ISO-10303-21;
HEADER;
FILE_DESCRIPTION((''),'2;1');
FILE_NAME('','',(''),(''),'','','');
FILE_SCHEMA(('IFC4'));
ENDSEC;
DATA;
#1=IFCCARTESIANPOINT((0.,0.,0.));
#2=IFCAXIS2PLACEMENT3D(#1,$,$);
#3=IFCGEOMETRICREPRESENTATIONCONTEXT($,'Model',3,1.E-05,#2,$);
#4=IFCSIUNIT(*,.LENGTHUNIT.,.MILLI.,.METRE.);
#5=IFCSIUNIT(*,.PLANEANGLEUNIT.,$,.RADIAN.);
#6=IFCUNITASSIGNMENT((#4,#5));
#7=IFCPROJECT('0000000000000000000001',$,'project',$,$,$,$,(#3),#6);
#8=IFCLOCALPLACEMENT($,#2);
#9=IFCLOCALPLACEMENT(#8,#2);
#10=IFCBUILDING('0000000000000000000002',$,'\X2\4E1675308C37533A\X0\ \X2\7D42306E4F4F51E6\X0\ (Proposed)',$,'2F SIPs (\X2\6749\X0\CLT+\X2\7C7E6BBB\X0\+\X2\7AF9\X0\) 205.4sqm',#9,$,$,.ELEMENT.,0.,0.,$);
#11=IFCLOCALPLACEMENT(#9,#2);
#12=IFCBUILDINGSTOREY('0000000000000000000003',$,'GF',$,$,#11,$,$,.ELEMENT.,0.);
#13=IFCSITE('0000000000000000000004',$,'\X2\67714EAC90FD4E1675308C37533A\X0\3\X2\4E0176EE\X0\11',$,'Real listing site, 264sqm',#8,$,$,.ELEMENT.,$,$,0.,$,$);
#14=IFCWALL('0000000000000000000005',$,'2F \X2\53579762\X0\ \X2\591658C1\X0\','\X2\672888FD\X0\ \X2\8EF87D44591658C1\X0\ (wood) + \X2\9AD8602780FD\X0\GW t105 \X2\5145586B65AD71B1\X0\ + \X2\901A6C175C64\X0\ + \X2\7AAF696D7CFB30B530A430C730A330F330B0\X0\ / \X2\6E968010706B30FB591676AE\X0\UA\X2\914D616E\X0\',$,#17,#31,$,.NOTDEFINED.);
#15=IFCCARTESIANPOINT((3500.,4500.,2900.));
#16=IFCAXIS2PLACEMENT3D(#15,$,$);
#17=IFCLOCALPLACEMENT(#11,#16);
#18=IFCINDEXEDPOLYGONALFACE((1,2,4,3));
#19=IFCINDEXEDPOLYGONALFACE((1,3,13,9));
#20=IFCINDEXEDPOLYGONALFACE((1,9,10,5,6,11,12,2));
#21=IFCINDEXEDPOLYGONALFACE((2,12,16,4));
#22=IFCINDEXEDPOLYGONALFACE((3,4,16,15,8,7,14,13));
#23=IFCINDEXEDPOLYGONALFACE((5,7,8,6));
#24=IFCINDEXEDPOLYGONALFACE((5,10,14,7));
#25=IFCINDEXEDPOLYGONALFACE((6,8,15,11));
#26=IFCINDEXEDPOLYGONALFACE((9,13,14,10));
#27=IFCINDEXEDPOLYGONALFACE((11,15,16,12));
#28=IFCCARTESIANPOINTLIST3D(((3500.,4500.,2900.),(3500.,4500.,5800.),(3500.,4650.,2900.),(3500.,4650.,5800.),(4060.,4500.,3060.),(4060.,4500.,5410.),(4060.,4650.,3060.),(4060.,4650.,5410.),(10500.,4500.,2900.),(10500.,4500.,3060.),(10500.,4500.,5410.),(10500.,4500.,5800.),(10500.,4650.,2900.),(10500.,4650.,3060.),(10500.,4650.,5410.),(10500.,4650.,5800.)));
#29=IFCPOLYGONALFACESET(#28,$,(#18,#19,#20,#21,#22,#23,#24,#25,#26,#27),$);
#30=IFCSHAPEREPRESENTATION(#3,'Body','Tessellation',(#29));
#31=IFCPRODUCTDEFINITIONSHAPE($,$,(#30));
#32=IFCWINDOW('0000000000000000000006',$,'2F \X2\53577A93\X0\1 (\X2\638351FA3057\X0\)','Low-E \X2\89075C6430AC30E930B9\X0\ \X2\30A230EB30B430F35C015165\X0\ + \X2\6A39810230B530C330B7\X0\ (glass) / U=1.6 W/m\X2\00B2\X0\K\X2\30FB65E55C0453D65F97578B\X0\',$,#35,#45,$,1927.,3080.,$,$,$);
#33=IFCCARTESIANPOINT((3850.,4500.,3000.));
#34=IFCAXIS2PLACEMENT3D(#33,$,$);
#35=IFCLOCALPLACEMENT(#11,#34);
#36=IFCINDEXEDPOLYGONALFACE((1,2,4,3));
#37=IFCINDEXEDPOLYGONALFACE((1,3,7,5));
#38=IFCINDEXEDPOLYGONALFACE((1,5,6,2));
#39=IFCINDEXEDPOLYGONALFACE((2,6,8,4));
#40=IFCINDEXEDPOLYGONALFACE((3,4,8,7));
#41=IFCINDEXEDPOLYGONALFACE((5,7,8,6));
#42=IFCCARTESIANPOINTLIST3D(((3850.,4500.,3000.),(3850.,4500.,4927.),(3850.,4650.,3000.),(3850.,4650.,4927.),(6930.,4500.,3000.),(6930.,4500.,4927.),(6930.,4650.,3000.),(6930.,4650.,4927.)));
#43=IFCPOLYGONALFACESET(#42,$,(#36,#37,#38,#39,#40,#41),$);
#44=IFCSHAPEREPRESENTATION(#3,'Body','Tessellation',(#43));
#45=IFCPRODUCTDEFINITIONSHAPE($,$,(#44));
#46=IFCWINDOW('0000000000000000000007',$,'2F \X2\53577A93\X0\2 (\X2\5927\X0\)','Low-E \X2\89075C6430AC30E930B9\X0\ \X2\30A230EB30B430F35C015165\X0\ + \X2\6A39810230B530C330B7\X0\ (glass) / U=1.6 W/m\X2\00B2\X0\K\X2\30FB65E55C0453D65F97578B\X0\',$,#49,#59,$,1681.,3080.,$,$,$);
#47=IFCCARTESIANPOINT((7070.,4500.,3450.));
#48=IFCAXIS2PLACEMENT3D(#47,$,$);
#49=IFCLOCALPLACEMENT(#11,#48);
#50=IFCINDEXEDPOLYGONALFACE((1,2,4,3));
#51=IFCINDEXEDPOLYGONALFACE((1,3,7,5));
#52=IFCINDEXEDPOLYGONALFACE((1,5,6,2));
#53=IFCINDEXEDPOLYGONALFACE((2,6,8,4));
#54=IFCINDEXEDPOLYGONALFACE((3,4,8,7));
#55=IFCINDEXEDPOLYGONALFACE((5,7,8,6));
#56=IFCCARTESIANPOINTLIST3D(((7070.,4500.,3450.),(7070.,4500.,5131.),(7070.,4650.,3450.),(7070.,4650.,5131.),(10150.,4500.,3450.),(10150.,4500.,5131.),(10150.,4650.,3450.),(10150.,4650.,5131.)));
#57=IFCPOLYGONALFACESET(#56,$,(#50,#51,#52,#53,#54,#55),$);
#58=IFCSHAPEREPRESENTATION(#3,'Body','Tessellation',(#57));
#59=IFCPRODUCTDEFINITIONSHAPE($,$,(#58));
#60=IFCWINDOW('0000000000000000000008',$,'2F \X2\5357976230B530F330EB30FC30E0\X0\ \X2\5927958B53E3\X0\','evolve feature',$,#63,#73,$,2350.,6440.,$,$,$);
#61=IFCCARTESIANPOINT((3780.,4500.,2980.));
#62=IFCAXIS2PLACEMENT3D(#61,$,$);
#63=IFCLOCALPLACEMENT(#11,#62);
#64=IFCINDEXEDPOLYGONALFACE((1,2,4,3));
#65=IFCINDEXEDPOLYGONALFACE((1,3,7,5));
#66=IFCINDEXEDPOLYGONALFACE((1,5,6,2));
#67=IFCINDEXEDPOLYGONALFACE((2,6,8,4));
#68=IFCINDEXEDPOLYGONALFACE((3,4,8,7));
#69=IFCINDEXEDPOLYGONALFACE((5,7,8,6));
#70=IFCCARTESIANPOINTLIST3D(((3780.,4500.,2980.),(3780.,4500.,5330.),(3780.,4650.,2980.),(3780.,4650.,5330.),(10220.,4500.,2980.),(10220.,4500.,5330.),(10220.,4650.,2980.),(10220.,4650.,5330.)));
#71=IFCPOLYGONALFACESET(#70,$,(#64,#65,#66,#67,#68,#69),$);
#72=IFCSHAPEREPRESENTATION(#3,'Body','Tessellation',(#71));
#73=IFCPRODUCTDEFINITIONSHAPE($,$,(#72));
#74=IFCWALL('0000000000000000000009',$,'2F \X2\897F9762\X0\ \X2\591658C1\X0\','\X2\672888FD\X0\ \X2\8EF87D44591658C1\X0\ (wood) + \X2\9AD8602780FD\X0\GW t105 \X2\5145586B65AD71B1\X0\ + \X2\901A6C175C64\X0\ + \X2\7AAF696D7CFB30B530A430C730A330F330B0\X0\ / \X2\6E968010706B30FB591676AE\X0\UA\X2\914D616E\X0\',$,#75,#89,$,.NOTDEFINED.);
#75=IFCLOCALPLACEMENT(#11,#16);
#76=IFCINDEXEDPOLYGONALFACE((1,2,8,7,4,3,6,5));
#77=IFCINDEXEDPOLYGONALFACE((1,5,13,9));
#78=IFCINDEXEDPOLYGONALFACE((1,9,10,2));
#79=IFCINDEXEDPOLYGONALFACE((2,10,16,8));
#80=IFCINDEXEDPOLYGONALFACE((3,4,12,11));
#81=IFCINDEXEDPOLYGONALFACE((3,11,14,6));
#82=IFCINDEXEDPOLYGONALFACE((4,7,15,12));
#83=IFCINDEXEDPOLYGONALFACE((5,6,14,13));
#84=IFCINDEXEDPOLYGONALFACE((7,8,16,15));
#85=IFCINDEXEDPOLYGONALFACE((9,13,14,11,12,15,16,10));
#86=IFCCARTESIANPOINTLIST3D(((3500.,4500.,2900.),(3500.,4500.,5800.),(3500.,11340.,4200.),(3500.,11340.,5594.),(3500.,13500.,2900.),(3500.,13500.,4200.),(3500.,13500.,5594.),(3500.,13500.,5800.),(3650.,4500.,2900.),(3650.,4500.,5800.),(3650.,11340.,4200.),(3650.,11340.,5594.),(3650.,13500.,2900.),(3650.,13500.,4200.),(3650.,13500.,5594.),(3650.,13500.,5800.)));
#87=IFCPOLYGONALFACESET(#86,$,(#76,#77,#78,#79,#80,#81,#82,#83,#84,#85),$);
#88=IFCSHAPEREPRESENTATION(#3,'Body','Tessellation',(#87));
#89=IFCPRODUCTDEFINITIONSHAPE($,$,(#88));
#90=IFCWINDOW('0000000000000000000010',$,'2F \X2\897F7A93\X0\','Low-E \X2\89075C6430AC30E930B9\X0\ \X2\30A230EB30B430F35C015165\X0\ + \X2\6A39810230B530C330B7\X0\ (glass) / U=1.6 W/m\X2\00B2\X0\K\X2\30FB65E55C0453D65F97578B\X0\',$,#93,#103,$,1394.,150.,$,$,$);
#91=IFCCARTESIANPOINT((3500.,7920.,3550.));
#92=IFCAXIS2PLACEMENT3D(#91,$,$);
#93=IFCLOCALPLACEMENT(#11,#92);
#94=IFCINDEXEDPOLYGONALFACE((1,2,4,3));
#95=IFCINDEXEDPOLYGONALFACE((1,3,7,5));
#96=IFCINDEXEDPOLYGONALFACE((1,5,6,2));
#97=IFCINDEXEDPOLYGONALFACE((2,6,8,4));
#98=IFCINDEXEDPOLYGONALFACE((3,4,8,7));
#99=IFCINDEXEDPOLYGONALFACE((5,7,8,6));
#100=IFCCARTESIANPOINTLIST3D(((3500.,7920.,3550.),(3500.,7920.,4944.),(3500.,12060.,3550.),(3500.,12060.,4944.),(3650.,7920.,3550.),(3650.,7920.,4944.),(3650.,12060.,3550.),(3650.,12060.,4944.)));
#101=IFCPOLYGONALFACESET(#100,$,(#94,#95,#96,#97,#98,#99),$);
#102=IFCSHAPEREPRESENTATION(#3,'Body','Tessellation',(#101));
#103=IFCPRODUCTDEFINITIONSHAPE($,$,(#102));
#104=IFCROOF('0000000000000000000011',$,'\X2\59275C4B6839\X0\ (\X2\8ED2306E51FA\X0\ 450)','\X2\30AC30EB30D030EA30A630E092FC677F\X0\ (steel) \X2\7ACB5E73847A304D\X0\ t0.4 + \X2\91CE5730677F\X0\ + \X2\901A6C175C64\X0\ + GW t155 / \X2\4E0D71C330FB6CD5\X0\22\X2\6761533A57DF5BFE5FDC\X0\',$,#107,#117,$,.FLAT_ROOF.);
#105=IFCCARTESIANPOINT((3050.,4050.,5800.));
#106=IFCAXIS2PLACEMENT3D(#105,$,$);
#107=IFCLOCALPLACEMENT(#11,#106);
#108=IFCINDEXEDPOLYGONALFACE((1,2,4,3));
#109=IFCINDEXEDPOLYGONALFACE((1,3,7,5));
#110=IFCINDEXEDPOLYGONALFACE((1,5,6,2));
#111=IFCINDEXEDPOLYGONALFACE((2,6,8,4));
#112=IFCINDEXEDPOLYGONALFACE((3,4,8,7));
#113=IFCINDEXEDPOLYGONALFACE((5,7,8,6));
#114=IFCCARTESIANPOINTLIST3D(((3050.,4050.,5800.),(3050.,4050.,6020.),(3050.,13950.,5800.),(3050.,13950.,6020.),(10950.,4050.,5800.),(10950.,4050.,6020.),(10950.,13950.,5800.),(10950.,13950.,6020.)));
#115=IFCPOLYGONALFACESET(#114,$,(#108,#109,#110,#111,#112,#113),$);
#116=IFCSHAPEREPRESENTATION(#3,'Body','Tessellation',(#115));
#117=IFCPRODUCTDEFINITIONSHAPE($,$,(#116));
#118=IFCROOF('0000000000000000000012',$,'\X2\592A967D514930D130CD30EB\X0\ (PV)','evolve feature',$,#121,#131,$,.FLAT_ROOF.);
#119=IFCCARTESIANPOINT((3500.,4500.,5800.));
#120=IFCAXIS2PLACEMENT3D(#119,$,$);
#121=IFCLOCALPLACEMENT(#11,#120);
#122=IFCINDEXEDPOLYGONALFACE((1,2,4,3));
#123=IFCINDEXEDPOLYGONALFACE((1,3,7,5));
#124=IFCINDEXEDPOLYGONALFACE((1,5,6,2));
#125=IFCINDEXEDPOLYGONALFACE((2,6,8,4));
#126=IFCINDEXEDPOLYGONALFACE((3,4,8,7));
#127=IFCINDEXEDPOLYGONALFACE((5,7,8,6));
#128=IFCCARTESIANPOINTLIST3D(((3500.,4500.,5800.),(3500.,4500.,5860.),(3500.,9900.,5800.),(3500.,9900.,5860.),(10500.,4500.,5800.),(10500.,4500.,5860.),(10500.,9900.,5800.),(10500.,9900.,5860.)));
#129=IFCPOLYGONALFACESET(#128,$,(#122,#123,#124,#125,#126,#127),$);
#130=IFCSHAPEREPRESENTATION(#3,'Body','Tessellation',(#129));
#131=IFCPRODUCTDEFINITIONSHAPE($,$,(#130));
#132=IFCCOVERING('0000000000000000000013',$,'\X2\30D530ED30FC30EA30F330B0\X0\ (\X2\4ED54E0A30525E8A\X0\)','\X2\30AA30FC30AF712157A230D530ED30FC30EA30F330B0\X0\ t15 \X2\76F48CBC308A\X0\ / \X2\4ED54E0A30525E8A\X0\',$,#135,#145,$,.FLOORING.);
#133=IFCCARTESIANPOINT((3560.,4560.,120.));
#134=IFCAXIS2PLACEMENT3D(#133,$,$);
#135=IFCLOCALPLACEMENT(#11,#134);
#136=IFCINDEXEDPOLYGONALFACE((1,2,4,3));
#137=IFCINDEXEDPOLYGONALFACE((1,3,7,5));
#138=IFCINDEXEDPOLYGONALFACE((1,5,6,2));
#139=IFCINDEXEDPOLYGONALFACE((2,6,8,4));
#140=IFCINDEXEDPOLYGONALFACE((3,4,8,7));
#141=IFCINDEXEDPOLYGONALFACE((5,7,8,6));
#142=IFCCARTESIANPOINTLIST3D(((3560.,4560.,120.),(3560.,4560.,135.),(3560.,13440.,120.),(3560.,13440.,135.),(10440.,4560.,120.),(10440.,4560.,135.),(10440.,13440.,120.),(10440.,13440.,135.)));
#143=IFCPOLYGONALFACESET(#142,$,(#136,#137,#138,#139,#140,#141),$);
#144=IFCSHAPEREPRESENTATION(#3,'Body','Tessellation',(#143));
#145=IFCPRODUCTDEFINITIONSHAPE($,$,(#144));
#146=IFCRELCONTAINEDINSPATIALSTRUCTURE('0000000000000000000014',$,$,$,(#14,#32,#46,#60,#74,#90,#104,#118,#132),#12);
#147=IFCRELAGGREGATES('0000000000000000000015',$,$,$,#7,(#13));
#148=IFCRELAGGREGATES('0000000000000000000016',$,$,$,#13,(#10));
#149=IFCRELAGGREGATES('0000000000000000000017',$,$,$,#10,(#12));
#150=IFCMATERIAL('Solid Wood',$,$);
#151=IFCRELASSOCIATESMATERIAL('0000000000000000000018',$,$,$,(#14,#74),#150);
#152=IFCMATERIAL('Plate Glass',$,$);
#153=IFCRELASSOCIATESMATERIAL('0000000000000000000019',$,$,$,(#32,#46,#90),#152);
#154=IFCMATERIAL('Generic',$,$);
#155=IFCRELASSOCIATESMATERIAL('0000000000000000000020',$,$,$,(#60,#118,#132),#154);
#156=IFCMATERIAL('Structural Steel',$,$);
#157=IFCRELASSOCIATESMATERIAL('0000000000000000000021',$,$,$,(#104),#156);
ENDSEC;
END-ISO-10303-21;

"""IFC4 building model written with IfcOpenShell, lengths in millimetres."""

from ifc_helpers import new_model, si_unit, frame, frame_2d, origin, place, context, project, spatial, rectangle, extrude, material, element, fill, save


model = new_model("IFC4")

# Units and contexts
model_context = context("Model", 3, precision=1e-05, world=origin())
ifc_project = project(units=[si_unit("LENGTHUNIT", "METRE", prefix="MILLI"), si_unit("PLANEANGLEUNIT", "RADIAN")], contexts=[model_context])

# Site, building, storey
site_placement = place(None, origin())
site = spatial("IfcSite", under=ifc_project, at=site_placement, Name="東京都世田谷区3丁目11", ObjectType="Real listing site, 264sqm", CompositionType="ELEMENT", RefElevation=0.0)
building_placement = place(site_placement, origin())
building = spatial("IfcBuilding", under=site, at=building_placement, Name="世田谷区 終の住処 (Proposed)", ObjectType="2F SIPs (杉CLT+籾殻+竹) 205.4sqm", CompositionType="ELEMENT", ElevationOfRefHeight=0.0, ElevationOfTerrain=0.0)
storey_placement = place(building_placement, origin())
storey = spatial("IfcBuildingStorey", under=building, at=storey_placement, Name="GF", CompositionType="ELEMENT", Elevation=0.0)

# Shared definitions
ifc_material_1 = material(Name="Solid Wood")

# Shared definitions
ifc_material_2 = material(Name="Plate Glass")
ifc_material_3 = material(Name="Generic")

# Wall, openings, windows
wall_1_placement = place(storey_placement, frame((3500.0, 4500.0, 2900.0)))
wall_1 = element("IfcWall", 1, at=wall_1_placement, inside=storey, material=ifc_material_1, Name="2F 南面 外壁", Description="木製 軸組外壁 (wood) + 高性能GW t105 充填断熱 + 通気層 + 窯業系サイディング / 準耐火・外皮UA配慮", PredefinedType="NOTDEFINED", context=model_context, shape_type="SweptSolid", body=[
    extrude(rectangle(XDim=7000.0, YDim=150.0, at=frame_2d((3500.0, 75.0))), frame((3500.0, 4500.0, 2900.0)), (0.0, 0.0, 1.0), 2900.0),
])
opening_1_placement = place(storey_placement, frame((3850.0, 4500.0, 3000.0)))
opening_1 = element("IfcOpeningElement", 2, at=opening_1_placement, cuts=wall_1, PredefinedType="NOTDEFINED", context=model_context, shape_type="SweptSolid", body=[
    extrude(rectangle(XDim=3080.0, YDim=150.0, at=frame_2d((1540.0, 75.0))), frame((3850.0, 4500.0, 3000.0)), (0.0, 0.0, 1.0), 1927.0),
])
opening_2_placement = place(storey_placement, frame((7070.0, 4500.0, 3450.0)))
opening_2 = element("IfcOpeningElement", 3, at=opening_2_placement, cuts=wall_1, PredefinedType="NOTDEFINED", context=model_context, shape_type="SweptSolid", body=[
    extrude(rectangle(XDim=3080.0, YDim=150.0, at=frame_2d((1540.0, 75.0))), frame((7070.0, 4500.0, 3450.0)), (0.0, 0.0, 1.0), 1681.0),
])
opening_3_placement = place(storey_placement, frame((3780.0, 4500.0, 2980.0)))
opening_3 = element("IfcOpeningElement", 4, at=opening_3_placement, cuts=wall_1, PredefinedType="NOTDEFINED", context=model_context, shape_type="SweptSolid", body=[
    extrude(rectangle(XDim=6440.0, YDim=150.0, at=frame_2d((3220.0, 75.0))), frame((3780.0, 4500.0, 2980.0)), (0.0, 0.0, 1.0), 2350.0),
])
window_1_placement = place(storey_placement, frame((3850.0, 4500.0, 3000.0)))
window_1 = element("IfcWindow", 5, at=window_1_placement, inside=storey, material=ifc_material_2, Name="2F 南窓1 (掃出し)", Description="Low-E 複層ガラス アルゴン封入 + 樹脂サッシ (glass) / U=1.6 W/m²K・日射取得型", OverallHeight=1927.0, OverallWidth=3080.0, context=model_context, shape_type="SweptSolid", body=[
    extrude(rectangle(XDim=3080.0, YDim=150.0, at=frame_2d((1540.0, 75.0))), frame((3850.0, 4500.0, 3000.0)), (0.0, 0.0, 1.0), 1927.0),
])
fill(opening_1, window_1)
window_2_placement = place(storey_placement, frame((7070.0, 4500.0, 3450.0)))
window_2 = element("IfcWindow", 6, at=window_2_placement, inside=storey, material=ifc_material_2, Name="2F 南窓2 (大)", Description="Low-E 複層ガラス アルゴン封入 + 樹脂サッシ (glass) / U=1.6 W/m²K・日射取得型", OverallHeight=1681.0, OverallWidth=3080.0, context=model_context, shape_type="SweptSolid", body=[
    extrude(rectangle(XDim=3080.0, YDim=150.0, at=frame_2d((1540.0, 75.0))), frame((7070.0, 4500.0, 3450.0)), (0.0, 0.0, 1.0), 1681.0),
])
fill(opening_2, window_2)
window_3_placement = place(storey_placement, frame((3780.0, 4500.0, 2980.0)))
window_3 = element("IfcWindow", 7, at=window_3_placement, inside=storey, material=ifc_material_3, Name="2F 南面サンルーム 大開口", Description="evolve feature", OverallHeight=2350.0, OverallWidth=6440.0, context=model_context, shape_type="SweptSolid", body=[
    extrude(rectangle(XDim=6440.0, YDim=150.0, at=frame_2d((3220.0, 75.0))), frame((3780.0, 4500.0, 2980.0)), (0.0, 0.0, 1.0), 2350.0),
])
fill(opening_3, window_3)

# Wall, opening, window
wall_2_placement = place(storey_placement, frame((3500.0, 4500.0, 2900.0)))
wall_2 = element("IfcWall", 8, at=wall_2_placement, inside=storey, material=ifc_material_1, Name="2F 西面 外壁", Description="木製 軸組外壁 (wood) + 高性能GW t105 充填断熱 + 通気層 + 窯業系サイディング / 準耐火・外皮UA配慮", PredefinedType="NOTDEFINED", context=model_context, shape_type="SweptSolid", body=[
    extrude(rectangle(XDim=150.0, YDim=9000.0, at=frame_2d((75.0, 4500.0))), frame((3500.0, 4500.0, 2900.0)), (0.0, 0.0, 1.0), 2900.0),
])
opening_4_placement = place(storey_placement, frame((3500.0, 7920.0, 3550.0)))
opening_4 = element("IfcOpeningElement", 9, at=opening_4_placement, cuts=wall_2, PredefinedType="NOTDEFINED", context=model_context, shape_type="SweptSolid", body=[
    extrude(rectangle(XDim=150.0, YDim=4140.0, at=frame_2d((75.0, 2070.0))), frame((3500.0, 7920.0, 3550.0)), (0.0, 0.0, 1.0), 1394.0),
])
window_4_placement = place(storey_placement, frame((3500.0, 7920.0, 3550.0)))
window_4 = element("IfcWindow", 10, at=window_4_placement, inside=storey, material=ifc_material_2, Name="2F 西窓", Description="Low-E 複層ガラス アルゴン封入 + 樹脂サッシ (glass) / U=1.6 W/m²K・日射取得型", OverallHeight=1394.0, OverallWidth=150.0, context=model_context, shape_type="SweptSolid", body=[
    extrude(rectangle(XDim=150.0, YDim=4140.0, at=frame_2d((75.0, 2070.0))), frame((3500.0, 7920.0, 3550.0)), (0.0, 0.0, 1.0), 1394.0),
])
fill(opening_4, window_4)

# Roofs
ifc_material_4 = material(Name="Structural Steel")
roof_1_placement = place(storey_placement, frame((3050.0, 4050.0, 5800.0)))
element("IfcRoof", 11, at=roof_1_placement, inside=storey, material=ifc_material_4, Name="大屋根 (軒の出 450)", Description="ガルバリウム鋼板 (steel) 立平葺き t0.4 + 野地板 + 通気層 + GW t155 / 不燃・法22条区域対応", PredefinedType="FLAT_ROOF", context=model_context, shape_type="SweptSolid", body=[
    extrude(rectangle(XDim=7900.0, YDim=9900.0, at=frame_2d((3950.0, 4950.0))), frame((3050.0, 4050.0, 5800.0)), (0.0, 0.0, 1.0), 220.0),
])
roof_2_placement = place(storey_placement, frame((3500.0, 4500.0, 5800.0)))
element("IfcRoof", 12, at=roof_2_placement, inside=storey, material=ifc_material_3, Name="太陽光パネル (PV)", Description="evolve feature", PredefinedType="FLAT_ROOF", context=model_context, shape_type="SweptSolid", body=[
    extrude(rectangle(XDim=7000.0, YDim=5400.0, at=frame_2d((3500.0, 2700.0))), frame((3500.0, 4500.0, 5800.0)), (0.0, 0.0, 1.0), 60.0),
])

# Covering
covering_placement = place(storey_placement, frame((3560.0, 4560.0, 120.0)))
element("IfcCovering", 13, at=covering_placement, inside=storey, material=ifc_material_3, Name="フローリング (仕上げ床)", Description="オーク無垢フローリング t15 直貼り / 仕上げ床", PredefinedType="FLOORING", context=model_context, shape_type="SweptSolid", body=[
    extrude(rectangle(XDim=6880.0, YDim=8880.0, at=frame_2d((3440.0, 4440.0))), frame((3560.0, 4560.0, 120.0)), (0.0, 0.0, 1.0), 15.0),
])

save(model, "model.ifc")
